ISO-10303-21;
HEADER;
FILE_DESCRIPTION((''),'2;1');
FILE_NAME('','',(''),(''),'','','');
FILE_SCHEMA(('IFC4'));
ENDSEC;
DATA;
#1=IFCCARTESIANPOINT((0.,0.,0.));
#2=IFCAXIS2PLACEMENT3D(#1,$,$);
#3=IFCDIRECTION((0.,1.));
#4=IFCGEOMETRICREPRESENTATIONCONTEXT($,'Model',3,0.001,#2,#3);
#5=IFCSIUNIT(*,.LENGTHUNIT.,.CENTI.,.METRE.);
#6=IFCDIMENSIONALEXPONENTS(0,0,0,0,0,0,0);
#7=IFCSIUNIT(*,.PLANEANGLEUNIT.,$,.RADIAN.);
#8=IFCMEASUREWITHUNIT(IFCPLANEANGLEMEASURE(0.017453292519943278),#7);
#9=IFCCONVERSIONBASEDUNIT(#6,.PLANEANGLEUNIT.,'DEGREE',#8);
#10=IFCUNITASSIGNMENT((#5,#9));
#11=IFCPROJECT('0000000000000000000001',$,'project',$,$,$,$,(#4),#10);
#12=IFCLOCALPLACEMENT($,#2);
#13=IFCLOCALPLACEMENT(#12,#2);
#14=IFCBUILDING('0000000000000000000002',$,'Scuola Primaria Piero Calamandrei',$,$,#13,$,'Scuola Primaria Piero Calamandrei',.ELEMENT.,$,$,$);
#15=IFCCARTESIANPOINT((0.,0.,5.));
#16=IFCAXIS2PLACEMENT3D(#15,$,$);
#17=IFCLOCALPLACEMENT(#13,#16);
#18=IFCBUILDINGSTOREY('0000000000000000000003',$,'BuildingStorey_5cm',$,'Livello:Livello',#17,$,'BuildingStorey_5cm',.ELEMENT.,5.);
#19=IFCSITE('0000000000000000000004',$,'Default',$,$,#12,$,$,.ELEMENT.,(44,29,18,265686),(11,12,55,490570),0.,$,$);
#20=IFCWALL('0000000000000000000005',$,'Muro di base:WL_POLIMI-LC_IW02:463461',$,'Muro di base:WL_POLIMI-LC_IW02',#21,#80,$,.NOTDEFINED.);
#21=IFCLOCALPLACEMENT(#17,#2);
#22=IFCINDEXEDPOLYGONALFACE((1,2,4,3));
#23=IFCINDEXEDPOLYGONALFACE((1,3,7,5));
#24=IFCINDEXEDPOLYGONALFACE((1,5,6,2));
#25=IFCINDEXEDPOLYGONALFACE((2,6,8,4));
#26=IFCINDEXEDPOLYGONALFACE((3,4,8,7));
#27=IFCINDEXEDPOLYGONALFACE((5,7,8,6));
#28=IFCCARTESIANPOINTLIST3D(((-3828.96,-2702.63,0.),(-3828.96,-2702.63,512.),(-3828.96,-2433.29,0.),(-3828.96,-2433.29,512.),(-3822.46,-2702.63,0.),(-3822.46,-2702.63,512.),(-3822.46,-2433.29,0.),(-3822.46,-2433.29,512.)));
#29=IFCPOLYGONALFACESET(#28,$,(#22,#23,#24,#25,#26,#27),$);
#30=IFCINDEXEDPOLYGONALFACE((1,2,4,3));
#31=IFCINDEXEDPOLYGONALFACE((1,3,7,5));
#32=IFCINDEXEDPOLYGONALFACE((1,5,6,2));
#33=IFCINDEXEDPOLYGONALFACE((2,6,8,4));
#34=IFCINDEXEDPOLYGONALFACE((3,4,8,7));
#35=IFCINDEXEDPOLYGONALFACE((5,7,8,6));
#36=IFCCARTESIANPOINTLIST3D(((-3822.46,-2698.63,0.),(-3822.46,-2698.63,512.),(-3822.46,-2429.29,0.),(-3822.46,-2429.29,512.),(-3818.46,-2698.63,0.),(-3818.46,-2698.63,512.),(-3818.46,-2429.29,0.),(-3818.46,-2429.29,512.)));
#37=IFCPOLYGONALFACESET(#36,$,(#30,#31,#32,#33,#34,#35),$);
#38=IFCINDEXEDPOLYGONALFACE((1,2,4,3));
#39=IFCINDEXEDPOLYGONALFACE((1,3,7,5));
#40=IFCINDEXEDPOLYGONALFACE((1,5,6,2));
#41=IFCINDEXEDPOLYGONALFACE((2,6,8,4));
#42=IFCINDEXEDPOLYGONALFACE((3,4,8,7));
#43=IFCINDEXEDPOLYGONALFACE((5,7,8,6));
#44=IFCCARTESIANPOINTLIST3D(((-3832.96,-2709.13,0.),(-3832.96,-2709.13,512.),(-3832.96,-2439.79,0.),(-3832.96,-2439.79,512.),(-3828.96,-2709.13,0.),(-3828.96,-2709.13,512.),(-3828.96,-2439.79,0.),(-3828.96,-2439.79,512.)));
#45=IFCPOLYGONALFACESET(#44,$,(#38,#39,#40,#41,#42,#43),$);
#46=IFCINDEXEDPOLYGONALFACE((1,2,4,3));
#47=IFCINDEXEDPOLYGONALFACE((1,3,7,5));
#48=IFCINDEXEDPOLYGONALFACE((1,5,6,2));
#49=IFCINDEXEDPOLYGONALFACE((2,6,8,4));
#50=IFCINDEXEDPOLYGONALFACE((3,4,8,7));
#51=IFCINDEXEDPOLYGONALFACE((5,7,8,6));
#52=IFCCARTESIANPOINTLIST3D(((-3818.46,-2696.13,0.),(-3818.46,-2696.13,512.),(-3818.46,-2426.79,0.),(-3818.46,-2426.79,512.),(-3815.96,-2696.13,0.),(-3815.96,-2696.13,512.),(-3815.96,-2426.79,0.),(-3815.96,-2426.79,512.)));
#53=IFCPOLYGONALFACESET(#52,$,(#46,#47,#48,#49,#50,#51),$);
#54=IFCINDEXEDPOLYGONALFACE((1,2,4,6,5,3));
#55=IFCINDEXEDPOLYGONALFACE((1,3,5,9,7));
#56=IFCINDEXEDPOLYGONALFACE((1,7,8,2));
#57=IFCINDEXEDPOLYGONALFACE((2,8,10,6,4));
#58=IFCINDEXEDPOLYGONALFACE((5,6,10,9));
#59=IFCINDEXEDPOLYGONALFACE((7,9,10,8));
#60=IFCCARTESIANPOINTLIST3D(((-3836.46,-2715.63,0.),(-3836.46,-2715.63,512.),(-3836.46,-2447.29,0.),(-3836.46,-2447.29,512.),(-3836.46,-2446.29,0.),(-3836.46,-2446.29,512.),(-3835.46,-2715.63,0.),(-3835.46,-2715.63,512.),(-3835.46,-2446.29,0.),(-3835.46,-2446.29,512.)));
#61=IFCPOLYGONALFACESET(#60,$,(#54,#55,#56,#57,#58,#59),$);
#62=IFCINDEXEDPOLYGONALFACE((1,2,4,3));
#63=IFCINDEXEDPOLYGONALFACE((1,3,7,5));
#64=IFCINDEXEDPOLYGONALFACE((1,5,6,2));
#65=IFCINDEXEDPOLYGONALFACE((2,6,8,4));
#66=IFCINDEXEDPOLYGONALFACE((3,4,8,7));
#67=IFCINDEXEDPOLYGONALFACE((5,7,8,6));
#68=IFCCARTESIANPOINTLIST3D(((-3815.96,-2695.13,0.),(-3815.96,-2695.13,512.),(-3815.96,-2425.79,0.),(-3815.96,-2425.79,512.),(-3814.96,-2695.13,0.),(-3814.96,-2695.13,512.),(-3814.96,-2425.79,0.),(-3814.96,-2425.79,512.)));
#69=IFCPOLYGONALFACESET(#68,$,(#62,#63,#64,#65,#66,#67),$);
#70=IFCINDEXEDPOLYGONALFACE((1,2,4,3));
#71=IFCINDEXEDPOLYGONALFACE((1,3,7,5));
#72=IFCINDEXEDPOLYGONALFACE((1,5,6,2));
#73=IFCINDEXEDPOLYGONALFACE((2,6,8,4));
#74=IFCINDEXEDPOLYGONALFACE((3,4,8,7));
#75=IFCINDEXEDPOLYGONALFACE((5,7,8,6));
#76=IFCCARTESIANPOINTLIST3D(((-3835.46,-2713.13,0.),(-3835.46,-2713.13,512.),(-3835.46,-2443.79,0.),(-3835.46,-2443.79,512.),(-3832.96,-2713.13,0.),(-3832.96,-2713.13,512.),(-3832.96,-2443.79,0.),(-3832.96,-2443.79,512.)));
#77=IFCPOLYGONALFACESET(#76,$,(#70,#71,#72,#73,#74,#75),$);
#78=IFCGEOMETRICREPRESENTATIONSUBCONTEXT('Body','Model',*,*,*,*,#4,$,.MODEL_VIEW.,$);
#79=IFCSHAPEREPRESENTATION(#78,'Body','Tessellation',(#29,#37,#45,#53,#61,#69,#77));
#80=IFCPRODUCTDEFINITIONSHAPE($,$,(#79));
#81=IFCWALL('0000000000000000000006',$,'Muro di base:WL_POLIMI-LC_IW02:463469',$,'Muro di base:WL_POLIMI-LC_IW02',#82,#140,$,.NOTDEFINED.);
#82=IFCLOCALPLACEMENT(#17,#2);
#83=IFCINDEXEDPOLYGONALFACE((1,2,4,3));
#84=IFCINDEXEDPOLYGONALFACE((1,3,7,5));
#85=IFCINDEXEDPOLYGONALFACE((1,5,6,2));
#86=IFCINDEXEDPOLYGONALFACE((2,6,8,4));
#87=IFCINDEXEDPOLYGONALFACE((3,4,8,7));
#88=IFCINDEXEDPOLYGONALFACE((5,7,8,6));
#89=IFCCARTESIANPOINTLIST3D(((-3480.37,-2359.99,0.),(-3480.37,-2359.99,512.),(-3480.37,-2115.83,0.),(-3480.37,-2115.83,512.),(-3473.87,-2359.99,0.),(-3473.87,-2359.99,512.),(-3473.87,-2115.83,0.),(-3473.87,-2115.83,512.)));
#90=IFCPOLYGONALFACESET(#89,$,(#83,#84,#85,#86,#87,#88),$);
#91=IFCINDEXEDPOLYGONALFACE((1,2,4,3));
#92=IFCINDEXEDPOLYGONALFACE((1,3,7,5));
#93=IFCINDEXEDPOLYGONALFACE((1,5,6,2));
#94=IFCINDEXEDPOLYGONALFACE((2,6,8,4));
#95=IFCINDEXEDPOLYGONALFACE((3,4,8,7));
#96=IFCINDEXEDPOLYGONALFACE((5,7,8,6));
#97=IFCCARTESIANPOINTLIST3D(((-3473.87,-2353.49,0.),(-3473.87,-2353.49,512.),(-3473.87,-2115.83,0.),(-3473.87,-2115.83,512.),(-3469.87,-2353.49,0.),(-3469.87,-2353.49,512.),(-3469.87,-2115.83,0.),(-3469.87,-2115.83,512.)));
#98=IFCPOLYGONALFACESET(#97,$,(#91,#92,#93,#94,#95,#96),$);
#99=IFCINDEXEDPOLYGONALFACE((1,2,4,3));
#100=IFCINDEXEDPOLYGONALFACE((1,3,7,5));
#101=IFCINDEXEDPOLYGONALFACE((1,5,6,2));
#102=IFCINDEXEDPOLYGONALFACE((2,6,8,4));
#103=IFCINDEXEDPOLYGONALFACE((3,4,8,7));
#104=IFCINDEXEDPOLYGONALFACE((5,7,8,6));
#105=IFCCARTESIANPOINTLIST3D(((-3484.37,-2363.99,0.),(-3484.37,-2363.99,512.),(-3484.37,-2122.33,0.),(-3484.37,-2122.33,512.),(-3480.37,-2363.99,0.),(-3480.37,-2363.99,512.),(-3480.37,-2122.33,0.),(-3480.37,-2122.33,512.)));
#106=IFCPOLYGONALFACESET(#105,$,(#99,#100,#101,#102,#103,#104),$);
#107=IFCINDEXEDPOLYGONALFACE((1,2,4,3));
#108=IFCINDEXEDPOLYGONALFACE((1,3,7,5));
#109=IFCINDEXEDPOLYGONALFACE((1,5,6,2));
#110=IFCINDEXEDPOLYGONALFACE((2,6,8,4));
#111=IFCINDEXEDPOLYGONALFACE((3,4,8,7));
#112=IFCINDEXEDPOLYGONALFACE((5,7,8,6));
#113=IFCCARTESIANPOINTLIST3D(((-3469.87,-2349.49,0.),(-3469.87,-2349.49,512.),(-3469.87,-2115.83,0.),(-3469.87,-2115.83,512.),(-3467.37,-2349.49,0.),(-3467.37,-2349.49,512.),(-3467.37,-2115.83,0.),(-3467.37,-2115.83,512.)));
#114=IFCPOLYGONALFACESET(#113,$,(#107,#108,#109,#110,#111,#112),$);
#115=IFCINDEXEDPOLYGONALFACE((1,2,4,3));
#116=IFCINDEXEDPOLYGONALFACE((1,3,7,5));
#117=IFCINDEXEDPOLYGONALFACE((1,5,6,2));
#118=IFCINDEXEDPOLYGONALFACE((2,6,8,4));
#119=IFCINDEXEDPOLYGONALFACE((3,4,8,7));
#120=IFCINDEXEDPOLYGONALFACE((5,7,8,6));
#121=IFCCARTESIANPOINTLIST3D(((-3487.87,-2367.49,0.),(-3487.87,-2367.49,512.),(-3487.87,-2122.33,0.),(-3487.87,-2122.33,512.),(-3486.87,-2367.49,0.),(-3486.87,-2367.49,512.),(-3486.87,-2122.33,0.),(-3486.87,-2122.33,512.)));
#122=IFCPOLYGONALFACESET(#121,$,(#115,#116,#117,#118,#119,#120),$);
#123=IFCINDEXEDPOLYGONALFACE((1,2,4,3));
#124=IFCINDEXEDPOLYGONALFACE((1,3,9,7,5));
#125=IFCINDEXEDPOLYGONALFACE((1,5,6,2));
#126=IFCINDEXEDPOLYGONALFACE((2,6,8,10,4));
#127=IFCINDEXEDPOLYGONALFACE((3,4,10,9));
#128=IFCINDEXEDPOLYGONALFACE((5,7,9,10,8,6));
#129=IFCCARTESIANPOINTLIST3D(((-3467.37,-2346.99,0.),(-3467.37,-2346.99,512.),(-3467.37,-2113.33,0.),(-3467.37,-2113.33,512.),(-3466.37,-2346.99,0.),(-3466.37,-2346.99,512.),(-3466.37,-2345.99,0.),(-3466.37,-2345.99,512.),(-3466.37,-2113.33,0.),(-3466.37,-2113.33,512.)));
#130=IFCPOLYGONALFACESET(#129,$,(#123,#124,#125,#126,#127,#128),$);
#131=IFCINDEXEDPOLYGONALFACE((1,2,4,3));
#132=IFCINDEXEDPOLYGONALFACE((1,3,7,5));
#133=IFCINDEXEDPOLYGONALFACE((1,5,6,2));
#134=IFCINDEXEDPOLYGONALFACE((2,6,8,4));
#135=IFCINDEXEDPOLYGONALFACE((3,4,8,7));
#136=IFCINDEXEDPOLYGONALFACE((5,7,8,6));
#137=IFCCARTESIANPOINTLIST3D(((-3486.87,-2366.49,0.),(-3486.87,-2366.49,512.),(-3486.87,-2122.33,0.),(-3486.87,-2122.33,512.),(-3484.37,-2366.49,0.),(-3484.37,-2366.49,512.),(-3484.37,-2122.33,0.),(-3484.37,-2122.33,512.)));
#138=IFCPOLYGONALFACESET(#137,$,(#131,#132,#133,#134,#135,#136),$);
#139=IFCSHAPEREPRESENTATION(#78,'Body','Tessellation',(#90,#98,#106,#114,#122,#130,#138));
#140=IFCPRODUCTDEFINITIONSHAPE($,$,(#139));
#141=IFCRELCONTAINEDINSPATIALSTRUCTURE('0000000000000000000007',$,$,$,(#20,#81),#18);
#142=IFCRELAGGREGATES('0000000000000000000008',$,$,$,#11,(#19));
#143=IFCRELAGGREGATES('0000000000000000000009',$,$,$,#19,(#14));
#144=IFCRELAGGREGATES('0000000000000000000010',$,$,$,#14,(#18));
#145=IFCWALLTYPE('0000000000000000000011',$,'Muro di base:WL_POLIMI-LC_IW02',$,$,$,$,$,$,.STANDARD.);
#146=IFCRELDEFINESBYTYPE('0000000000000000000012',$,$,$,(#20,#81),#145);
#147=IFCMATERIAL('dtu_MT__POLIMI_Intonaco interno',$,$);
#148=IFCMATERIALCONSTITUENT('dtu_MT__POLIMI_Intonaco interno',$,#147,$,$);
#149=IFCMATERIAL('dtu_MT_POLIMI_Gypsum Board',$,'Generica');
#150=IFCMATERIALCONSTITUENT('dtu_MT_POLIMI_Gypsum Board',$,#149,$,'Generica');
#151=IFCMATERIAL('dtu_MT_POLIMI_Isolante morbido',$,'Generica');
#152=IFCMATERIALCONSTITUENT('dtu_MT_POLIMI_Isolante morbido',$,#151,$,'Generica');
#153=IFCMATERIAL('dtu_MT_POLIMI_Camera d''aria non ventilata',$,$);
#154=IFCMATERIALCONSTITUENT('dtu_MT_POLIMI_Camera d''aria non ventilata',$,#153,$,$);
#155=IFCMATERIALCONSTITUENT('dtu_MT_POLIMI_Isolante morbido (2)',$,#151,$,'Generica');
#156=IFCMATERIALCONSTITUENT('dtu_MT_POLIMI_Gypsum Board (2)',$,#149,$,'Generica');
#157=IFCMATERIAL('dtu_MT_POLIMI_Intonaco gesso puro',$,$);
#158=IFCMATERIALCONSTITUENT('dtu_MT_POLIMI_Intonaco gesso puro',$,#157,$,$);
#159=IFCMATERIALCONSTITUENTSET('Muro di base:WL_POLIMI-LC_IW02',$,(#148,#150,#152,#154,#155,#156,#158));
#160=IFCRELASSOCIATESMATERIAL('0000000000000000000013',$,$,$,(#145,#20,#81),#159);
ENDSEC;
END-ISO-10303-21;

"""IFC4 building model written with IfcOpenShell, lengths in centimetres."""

from ifc_helpers import new_model, entity, si_unit, converted_unit, direction, frame, origin, place, context, subcontext, project, spatial, indexed_curve, outline, extrude, material, constituent, constituent_set, type_object, element, save


model = new_model("IFC4")

# Units and contexts
model_context = context("Model", 3, precision=0.001, world=origin(), true_north=direction((0.0, 1.0)))
body_context = subcontext(model_context, "Body", "Model", "MODEL_VIEW")
ifc_project = project(units=[si_unit("LENGTHUNIT", "METRE", prefix="CENTI"), converted_unit("PLANEANGLEUNIT", "DEGREE", entity("IfcPlaneAngleMeasure", 0.017453292519943278), si_unit("PLANEANGLEUNIT", "RADIAN"), dimensions=[0, 0, 0, 0, 0, 0, 0])], contexts=[model_context])

# Site, building, storey
site_placement = place(None, origin())
site = spatial("IfcSite", under=ifc_project, at=site_placement, Name="Default", CompositionType="ELEMENT", RefLatitude=(44, 29, 18, 265686), RefLongitude=(11, 12, 55, 490570), RefElevation=0.0)
building_placement = place(site_placement, origin())
building = spatial("IfcBuilding", under=site, at=building_placement, Name="Scuola Primaria Piero Calamandrei", LongName="Scuola Primaria Piero Calamandrei", CompositionType="ELEMENT")
storey_placement = place(building_placement, frame((0.0, 0.0, 5.0)))
storey = spatial("IfcBuildingStorey", under=building, at=storey_placement, Name="BuildingStorey_5cm", ObjectType="Livello:Livello", LongName="BuildingStorey_5cm", CompositionType="ELEMENT", Elevation=5.0)

# Shared definitions
ifc_material_1 = material(Name="dtu_MT_POLIMI_Intonaco gesso puro")

# Wall
ifc_material_2 = material(Name="dtu_MT_POLIMI_Isolante morbido", Category="Generica")
ifc_material_3 = material(Name="dtu_MT_POLIMI_Gypsum Board", Category="Generica")
ifc_material_4 = material(Name="dtu_MT__POLIMI_Intonaco interno")
ifc_constituent_1 = constituent(ifc_material_4, Name="dtu_MT__POLIMI_Intonaco interno")
ifc_constituent_2 = constituent(ifc_material_3, Name="dtu_MT_POLIMI_Gypsum Board", Category="Generica")
ifc_constituent_3 = constituent(ifc_material_2, Name="dtu_MT_POLIMI_Isolante morbido", Category="Generica")
ifc_material_5 = material(Name="dtu_MT_POLIMI_Camera d'aria non ventilata")
ifc_constituent_4 = constituent(ifc_material_5, Name="dtu_MT_POLIMI_Camera d'aria non ventilata")
ifc_constituent_5 = constituent(ifc_material_2, Name="dtu_MT_POLIMI_Isolante morbido (2)", Category="Generica")
ifc_constituent_6 = constituent(ifc_material_3, Name="dtu_MT_POLIMI_Gypsum Board (2)", Category="Generica")
ifc_constituent_7 = constituent(ifc_material_1, Name="dtu_MT_POLIMI_Intonaco gesso puro")
ifc_constituent_set_1 = constituent_set(constituents=[ifc_constituent_1, ifc_constituent_2, ifc_constituent_3, ifc_constituent_4, ifc_constituent_5, ifc_constituent_6, ifc_constituent_7], Name="Muro di base:WL_POLIMI-LC_IW02")
wall_type_1 = type_object("IfcWallType", Name="Muro di base:WL_POLIMI-LC_IW02", PredefinedType="STANDARD", material=ifc_constituent_set_1)
wall_1_placement = place(storey_placement, frame((-3825.71, -2425.79, 0.0), z_axis=(0.0, 0.0, 1.0), x_axis=(0.0, -1.0, 0.0)))
element("IfcWall", 1, at=wall_1_placement, inside=storey, type_object=wall_type_1, material=ifc_constituent_set_1, Name="Muro di base:WL_POLIMI-LC_IW02:463461", ObjectType="Muro di base:WL_POLIMI-LC_IW02", PredefinedType="NOTDEFINED", context=body_context, shape_type="SweptSolid", body=[
    extrude(outline(indexed_curve([(-134.67, -3.25), (134.67, -3.25), (134.67, 3.25), (-134.67, 3.25), (-134.67, -3.25)], self_intersect=False)), frame((142.17, 0.0, 0.0)), (0.0, 0.0, 1.0), 512.0),
    extrude(outline(indexed_curve([(-134.67, -2.0), (134.67, -2.0), (134.67, 2.0), (-134.67, 2.0), (-134.67, -2.0)], self_intersect=False)), frame((138.17, 5.25, 0.0)), (0.0, 0.0, 1.0), 512.0),
    extrude(outline(indexed_curve([(-134.67, -2.0), (134.67, -2.0), (134.67, 2.0), (-134.67, 2.0), (-134.67, -2.0)], self_intersect=False)), frame((148.67, -5.25, 0.0)), (0.0, 0.0, 1.0), 512.0),
    extrude(outline(indexed_curve([(-134.67, -1.25), (134.67, -1.25), (134.67, 1.25), (-134.67, 1.25), (-134.67, -1.25)], self_intersect=False)), frame((135.67, 8.5, 0.0)), (0.0, 0.0, 1.0), 512.0),
    extrude(outline(indexed_curve([(-106.94, -0.4), (161.4, -0.4), (161.4, 0.6), (-107.94, 0.6), (-107.94, -0.4), (-106.94, -0.4)], self_intersect=False)), frame((128.44, -10.35, 0.0)), (0.0, 0.0, 1.0), 512.0),
    extrude(outline(indexed_curve([(-0.5, -134.67), (0.5, -134.67), (0.5, 134.67), (-0.5, 134.67), (-0.5, -134.67)], self_intersect=False)), frame((134.67, 10.25, 0.0), z_axis=(0.0, 0.0, 1.0), x_axis=(0.0, -1.0, 0.0)), (0.0, 0.0, 1.0), 512.0),
    extrude(outline(indexed_curve([(-134.67, -1.25), (134.67, -1.25), (134.67, 1.25), (-134.67, 1.25), (-134.67, -1.25)], self_intersect=False)), frame((152.67, -8.5, 0.0)), (0.0, 0.0, 1.0), 512.0),
])

# Wall
wall_2_placement = place(storey_placement, frame((-3477.12, -2122.33, 0.0), z_axis=(0.0, 0.0, 1.0), x_axis=(0.0, -1.0, 0.0)))
element("IfcWall", 2, at=wall_2_placement, inside=storey, type_object=wall_type_1, material=ifc_constituent_set_1, Name="Muro di base:WL_POLIMI-LC_IW02:463469", ObjectType="Muro di base:WL_POLIMI-LC_IW02", PredefinedType="NOTDEFINED", context=body_context, shape_type="SweptSolid", body=[
    extrude(outline(indexed_curve([(-122.08, -3.25), (122.08, -3.25), (122.08, 3.25), (-122.08, 3.25), (-122.08, -3.25)], self_intersect=False)), frame((115.58, 0.0, 0.0)), (0.0, 0.0, 1.0), 512.0),
    extrude(outline(indexed_curve([(-118.83, -2.0), (118.83, -2.0), (118.83, 2.0), (-118.83, 2.0), (-118.83, -2.0)], self_intersect=False)), frame((112.33, 5.25, 0.0)), (0.0, 0.0, 1.0), 512.0),
    extrude(outline(indexed_curve([(-120.83, -2.0), (120.83, -2.0), (120.83, 2.0), (-120.83, 2.0), (-120.83, -2.0)], self_intersect=False)), frame((120.83, -5.25, 0.0)), (0.0, 0.0, 1.0), 512.0),
    extrude(outline(indexed_curve([(-116.83, -1.25), (116.83, -1.25), (116.83, 1.25), (-116.83, 1.25), (-116.83, -1.25)], self_intersect=False)), frame((110.33, 8.5, 0.0)), (0.0, 0.0, 1.0), 512.0),
    extrude(outline(indexed_curve([(-0.5, -122.58), (0.5, -122.58), (0.5, 122.58), (-0.5, 122.58), (-0.5, -122.58)], self_intersect=False)), frame((122.58, -10.25, 0.0), z_axis=(0.0, 0.0, 1.0), x_axis=(0.0, 1.0, 0.0)), (0.0, 0.0, 1.0), 512.0),
    extrude(outline(indexed_curve([(-92.67, -0.4), (140.0, -0.4), (140.0, 0.6), (-93.67, 0.6), (-93.67, -0.4), (-92.67, -0.4)], self_intersect=False)), frame((131.0, 10.35, 0.0), z_axis=(0.0, 0.0, 1.0), x_axis=(-1.0, 0.0, 0.0)), (0.0, 0.0, 1.0), 512.0),
    extrude(outline(indexed_curve([(-122.08, -1.25), (122.08, -1.25), (122.08, 1.25), (-122.08, 1.25), (-122.08, -1.25)], self_intersect=False)), frame((122.08, -8.5, 0.0)), (0.0, 0.0, 1.0), 512.0),
])

save(model, "model.ifc")
